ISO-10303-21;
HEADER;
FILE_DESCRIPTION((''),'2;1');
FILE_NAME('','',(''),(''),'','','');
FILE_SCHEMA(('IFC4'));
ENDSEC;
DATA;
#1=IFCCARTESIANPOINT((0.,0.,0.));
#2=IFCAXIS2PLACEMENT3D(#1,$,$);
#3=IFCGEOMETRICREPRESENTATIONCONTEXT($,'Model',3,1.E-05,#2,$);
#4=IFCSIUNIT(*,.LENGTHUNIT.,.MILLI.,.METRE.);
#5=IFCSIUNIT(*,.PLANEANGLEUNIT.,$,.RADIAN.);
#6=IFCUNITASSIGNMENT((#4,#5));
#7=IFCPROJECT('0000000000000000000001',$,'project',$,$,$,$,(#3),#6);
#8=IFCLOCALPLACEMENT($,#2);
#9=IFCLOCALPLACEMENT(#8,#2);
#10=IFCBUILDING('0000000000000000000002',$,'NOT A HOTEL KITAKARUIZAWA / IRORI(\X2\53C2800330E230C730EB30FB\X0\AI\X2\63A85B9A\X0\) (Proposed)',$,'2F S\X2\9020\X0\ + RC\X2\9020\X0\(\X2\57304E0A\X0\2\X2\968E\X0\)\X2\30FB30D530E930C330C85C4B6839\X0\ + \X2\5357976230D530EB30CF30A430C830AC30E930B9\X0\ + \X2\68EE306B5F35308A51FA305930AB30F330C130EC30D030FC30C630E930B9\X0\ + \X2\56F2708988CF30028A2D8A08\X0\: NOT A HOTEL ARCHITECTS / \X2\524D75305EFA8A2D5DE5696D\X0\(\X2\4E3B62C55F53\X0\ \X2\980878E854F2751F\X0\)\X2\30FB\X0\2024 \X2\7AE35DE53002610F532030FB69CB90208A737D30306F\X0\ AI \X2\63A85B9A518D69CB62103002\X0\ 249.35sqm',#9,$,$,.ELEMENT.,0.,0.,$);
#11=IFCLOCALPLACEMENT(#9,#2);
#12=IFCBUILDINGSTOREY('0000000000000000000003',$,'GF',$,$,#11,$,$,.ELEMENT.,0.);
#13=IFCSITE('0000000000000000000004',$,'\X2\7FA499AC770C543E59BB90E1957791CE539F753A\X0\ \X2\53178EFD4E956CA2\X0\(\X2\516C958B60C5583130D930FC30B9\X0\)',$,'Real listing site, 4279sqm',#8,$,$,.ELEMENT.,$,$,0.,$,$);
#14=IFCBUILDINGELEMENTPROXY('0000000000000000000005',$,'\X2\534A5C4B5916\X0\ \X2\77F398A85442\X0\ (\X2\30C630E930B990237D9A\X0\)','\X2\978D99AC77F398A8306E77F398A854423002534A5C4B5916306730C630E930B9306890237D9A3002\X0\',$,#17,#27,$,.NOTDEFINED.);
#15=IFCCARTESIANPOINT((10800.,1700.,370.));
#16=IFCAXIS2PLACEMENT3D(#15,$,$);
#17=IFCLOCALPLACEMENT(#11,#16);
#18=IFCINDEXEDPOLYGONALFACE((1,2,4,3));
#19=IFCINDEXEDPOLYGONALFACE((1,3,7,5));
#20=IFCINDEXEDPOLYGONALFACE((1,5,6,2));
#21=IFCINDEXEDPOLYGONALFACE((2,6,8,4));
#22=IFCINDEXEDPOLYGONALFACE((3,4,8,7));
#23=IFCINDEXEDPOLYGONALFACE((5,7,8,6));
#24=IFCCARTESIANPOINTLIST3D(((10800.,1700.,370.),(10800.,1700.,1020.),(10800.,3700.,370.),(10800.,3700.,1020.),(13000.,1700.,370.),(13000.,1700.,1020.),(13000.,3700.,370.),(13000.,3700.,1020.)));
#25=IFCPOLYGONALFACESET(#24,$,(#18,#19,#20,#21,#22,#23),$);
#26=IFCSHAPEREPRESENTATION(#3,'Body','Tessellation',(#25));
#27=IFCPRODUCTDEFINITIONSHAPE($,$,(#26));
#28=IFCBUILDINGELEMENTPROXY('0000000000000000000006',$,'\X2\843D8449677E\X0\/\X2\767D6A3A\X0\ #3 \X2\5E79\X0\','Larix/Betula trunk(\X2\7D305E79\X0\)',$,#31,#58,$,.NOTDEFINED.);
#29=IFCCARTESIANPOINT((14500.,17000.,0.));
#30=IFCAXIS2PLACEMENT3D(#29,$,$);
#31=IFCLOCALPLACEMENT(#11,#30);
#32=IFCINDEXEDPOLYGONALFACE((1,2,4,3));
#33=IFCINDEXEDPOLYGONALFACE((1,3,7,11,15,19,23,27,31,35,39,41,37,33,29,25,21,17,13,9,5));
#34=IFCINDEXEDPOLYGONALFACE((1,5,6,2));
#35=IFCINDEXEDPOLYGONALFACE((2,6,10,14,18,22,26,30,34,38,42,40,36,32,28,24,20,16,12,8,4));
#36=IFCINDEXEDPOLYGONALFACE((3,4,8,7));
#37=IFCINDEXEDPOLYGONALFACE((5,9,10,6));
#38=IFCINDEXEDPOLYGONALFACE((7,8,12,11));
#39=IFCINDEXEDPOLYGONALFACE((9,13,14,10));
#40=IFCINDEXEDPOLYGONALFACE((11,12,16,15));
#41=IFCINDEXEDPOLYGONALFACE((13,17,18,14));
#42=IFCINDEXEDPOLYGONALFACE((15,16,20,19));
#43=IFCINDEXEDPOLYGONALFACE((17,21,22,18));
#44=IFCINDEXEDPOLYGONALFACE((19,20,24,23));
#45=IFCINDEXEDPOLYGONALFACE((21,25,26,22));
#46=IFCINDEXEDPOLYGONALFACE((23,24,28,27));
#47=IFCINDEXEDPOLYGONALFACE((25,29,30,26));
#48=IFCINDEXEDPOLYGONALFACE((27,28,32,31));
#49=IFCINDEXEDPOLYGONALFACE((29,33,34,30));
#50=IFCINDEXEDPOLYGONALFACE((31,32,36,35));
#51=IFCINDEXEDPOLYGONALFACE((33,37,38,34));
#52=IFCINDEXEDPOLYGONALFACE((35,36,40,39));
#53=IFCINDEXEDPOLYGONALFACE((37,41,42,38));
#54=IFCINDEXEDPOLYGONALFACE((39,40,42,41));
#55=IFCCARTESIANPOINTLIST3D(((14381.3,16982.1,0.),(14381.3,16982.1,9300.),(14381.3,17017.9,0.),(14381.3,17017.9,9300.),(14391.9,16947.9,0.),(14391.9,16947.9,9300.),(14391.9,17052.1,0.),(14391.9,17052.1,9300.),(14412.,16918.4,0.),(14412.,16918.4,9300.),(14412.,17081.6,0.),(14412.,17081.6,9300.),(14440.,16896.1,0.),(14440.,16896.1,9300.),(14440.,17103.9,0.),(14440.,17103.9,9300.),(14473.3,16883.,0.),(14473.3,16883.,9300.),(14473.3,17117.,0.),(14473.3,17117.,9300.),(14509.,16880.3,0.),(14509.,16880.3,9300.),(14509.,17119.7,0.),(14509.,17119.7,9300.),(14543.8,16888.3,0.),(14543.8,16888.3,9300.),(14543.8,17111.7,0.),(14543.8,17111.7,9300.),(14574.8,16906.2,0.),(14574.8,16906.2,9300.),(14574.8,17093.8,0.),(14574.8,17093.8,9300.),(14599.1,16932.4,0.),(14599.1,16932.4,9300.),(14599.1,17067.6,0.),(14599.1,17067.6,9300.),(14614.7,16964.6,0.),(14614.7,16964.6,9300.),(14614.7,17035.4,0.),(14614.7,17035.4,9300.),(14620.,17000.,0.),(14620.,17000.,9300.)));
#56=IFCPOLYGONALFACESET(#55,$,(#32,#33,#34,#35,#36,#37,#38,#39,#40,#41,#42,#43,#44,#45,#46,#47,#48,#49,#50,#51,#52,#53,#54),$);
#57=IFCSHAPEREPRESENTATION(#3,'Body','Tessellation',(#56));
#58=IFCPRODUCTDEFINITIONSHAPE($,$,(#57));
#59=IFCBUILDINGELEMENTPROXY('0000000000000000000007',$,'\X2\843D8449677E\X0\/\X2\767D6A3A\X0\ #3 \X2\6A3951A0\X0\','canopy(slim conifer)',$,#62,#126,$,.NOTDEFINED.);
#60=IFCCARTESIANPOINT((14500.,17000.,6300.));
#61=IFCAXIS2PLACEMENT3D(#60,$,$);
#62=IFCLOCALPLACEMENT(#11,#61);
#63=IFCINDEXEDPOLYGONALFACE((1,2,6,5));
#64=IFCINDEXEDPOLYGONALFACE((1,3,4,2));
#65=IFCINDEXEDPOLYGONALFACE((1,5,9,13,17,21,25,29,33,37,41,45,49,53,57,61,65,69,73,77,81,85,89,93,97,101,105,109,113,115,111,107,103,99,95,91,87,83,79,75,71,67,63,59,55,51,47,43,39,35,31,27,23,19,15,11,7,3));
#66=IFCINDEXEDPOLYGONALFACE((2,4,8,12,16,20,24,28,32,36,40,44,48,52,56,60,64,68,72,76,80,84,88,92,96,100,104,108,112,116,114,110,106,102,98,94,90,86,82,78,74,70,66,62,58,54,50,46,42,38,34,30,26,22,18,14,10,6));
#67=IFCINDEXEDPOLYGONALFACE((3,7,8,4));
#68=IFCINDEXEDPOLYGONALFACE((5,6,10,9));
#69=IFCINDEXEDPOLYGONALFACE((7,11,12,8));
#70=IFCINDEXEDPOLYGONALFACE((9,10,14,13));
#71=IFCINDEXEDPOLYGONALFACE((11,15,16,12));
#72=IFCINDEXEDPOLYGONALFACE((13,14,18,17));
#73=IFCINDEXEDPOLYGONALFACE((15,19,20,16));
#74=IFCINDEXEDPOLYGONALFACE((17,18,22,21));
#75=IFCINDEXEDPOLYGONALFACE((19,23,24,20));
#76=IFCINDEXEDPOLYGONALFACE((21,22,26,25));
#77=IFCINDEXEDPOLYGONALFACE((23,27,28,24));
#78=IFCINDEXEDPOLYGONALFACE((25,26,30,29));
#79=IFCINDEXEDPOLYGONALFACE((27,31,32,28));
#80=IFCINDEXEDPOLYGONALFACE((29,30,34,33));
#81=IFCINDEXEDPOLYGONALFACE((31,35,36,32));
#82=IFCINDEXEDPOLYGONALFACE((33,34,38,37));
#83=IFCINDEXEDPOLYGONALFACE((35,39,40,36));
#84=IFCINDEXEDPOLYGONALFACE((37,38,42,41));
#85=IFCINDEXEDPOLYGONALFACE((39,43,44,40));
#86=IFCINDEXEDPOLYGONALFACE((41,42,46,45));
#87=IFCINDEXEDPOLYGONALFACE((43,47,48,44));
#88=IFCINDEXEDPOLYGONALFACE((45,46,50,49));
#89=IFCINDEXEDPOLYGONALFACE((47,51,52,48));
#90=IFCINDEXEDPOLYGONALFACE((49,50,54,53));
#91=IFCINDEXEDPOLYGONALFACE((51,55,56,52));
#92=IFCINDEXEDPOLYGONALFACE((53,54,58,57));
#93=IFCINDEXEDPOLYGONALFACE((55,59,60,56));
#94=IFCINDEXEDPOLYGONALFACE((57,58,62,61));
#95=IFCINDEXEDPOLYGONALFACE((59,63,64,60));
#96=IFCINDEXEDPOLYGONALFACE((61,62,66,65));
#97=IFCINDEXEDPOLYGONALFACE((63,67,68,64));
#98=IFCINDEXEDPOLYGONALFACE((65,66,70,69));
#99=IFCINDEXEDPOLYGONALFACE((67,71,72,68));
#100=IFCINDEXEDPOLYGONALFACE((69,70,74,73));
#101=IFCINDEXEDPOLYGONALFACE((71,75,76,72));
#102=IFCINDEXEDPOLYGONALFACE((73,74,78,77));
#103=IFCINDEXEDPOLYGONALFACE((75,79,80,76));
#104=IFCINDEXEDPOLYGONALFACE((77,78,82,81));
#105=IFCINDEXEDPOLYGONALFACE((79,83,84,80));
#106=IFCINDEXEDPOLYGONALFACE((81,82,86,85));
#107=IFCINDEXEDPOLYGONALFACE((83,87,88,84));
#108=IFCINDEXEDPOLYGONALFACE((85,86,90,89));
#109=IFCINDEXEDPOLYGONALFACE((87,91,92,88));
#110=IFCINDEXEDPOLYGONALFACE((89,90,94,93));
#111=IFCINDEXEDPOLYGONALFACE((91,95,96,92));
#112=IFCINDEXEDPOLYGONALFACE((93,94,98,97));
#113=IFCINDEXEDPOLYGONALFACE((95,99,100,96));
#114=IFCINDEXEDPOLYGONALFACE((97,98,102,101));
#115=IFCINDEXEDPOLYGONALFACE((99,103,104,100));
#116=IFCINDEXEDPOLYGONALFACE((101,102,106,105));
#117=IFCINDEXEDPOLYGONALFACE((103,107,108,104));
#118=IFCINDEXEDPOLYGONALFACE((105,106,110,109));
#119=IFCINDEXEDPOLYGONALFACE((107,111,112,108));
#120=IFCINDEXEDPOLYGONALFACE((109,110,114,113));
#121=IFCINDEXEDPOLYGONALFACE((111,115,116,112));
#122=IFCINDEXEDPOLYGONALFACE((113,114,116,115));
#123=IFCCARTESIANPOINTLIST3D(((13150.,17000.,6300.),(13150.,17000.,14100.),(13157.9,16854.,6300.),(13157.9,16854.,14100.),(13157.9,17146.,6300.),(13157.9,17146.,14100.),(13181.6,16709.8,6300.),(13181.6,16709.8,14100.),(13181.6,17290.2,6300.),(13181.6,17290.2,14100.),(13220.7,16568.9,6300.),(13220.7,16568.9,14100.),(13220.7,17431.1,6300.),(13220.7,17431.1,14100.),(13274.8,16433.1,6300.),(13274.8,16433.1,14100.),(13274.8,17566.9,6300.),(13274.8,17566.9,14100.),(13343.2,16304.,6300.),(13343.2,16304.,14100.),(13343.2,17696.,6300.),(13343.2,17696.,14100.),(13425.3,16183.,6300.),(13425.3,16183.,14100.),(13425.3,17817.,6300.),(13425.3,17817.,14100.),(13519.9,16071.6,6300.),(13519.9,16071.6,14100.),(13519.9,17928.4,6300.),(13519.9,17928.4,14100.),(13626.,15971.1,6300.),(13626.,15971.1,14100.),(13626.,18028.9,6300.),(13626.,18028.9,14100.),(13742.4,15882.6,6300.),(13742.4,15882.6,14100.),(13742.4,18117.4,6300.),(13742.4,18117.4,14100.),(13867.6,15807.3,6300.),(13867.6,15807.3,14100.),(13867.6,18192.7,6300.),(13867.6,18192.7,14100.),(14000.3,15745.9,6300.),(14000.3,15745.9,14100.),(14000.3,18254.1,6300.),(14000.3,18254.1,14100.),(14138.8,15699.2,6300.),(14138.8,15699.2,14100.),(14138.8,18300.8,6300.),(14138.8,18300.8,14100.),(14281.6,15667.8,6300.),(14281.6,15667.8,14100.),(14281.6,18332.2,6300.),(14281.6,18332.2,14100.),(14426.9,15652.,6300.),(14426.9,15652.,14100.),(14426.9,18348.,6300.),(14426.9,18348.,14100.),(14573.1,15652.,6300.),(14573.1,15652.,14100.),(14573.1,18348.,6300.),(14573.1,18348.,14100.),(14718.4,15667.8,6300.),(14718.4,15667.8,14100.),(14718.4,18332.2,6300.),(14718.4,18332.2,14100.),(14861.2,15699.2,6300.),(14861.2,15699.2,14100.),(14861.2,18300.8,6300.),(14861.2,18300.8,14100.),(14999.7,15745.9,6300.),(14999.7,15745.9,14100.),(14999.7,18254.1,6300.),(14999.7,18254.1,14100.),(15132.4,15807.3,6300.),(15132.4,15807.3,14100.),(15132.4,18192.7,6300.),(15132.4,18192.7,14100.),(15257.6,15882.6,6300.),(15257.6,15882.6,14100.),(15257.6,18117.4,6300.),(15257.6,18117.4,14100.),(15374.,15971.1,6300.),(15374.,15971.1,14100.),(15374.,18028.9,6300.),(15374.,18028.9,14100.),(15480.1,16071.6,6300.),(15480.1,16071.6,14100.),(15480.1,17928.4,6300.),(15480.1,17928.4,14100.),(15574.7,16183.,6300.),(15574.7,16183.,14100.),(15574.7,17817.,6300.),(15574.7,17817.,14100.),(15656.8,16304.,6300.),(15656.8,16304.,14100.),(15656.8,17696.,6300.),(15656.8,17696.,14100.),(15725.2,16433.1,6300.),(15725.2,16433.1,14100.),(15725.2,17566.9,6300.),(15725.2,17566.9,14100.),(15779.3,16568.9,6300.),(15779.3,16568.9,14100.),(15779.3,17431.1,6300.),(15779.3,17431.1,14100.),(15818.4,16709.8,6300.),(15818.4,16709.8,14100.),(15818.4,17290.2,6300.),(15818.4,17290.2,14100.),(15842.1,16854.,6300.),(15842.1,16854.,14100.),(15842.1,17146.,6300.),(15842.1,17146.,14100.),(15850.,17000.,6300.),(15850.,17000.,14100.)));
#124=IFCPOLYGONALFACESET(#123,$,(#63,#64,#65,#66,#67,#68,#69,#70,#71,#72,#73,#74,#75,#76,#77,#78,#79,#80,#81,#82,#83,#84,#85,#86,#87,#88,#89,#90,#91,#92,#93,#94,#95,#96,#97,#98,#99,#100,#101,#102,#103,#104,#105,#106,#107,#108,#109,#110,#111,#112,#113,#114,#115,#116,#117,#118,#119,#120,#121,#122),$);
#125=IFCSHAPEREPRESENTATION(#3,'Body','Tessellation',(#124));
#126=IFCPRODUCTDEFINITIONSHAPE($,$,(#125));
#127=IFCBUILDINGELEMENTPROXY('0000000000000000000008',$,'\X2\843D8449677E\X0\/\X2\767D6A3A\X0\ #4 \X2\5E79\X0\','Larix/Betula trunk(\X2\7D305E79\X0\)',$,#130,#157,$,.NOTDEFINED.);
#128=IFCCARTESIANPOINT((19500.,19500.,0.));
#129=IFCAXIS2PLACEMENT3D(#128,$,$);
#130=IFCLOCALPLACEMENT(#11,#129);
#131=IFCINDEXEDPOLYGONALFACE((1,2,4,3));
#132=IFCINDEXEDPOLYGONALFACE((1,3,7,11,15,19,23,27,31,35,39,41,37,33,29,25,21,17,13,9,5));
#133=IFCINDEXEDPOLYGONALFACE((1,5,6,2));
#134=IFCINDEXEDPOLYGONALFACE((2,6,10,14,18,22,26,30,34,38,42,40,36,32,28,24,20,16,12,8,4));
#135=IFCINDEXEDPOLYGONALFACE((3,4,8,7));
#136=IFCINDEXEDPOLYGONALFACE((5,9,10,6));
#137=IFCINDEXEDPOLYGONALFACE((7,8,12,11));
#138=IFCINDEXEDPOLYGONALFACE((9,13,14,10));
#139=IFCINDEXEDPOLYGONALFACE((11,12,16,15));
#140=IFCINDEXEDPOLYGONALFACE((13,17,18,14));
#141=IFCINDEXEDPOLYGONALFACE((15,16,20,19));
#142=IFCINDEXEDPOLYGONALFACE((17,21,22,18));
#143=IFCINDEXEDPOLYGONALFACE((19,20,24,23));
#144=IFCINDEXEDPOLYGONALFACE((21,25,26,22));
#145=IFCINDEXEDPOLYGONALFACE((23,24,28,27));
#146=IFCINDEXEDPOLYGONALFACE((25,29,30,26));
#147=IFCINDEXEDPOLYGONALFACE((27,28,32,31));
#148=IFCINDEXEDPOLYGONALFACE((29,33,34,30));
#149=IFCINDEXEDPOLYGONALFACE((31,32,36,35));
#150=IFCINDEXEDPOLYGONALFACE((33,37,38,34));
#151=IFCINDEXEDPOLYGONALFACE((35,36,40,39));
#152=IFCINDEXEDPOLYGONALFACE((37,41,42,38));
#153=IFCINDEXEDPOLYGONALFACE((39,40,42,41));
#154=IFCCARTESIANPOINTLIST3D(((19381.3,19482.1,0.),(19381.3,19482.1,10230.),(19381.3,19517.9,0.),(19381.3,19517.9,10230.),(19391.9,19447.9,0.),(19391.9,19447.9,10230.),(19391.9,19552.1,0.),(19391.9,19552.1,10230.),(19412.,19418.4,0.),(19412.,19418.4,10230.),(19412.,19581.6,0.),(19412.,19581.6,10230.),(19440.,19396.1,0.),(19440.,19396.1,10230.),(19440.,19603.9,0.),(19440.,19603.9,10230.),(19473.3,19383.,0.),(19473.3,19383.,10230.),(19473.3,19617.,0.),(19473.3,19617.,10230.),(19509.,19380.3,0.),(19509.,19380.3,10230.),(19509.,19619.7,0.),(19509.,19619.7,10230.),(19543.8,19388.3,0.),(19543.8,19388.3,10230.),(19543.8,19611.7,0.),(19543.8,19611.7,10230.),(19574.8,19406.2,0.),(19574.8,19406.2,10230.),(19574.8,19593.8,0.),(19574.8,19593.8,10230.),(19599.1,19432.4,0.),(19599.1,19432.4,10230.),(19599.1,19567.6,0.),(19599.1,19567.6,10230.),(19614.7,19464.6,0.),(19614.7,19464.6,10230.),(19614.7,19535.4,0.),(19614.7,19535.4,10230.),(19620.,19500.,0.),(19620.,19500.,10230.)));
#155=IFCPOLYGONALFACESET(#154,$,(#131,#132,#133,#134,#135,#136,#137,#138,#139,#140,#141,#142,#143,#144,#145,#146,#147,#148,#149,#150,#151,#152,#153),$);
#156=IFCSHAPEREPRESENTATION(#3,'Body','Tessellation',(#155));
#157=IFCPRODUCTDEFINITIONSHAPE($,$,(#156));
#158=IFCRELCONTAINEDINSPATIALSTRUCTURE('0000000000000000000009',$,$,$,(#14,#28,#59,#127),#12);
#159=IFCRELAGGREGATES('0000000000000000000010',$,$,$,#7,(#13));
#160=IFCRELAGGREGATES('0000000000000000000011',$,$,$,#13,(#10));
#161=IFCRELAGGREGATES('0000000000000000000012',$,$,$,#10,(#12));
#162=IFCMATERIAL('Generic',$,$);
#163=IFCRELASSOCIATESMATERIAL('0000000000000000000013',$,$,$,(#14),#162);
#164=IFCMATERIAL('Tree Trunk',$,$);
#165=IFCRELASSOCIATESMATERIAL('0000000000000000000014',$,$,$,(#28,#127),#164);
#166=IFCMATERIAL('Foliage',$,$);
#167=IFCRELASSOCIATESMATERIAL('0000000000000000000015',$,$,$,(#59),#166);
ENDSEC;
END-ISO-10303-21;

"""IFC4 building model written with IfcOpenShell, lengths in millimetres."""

from ifc_helpers import new_model, si_unit, frame, frame_2d, origin, origin_2d, place, context, project, spatial, rectangle, circle, extrude, material, element, save


model = new_model("IFC4")

# Units and contexts
model_context = context("Model", 3, precision=1e-05, world=origin())
ifc_project = project(units=[si_unit("LENGTHUNIT", "METRE", prefix="MILLI"), si_unit("PLANEANGLEUNIT", "RADIAN")], contexts=[model_context])

# Site, building, storey
site_placement = place(None, origin())
site = spatial("IfcSite", under=ifc_project, at=site_placement, Name="群馬県吾妻郡長野原町 北軽井沢(公開情報ベース)", ObjectType="Real listing site, 4279sqm", CompositionType="ELEMENT", RefElevation=0.0)
building_placement = place(site_placement, origin())
building = spatial("IfcBuilding", under=site, at=building_placement, Name="NOT A HOTEL KITAKARUIZAWA / IRORI(参考モデル・AI推定) (Proposed)", ObjectType="2F S造 + RC造(地上2階)・フラット屋根 + 南面フルハイトガラス + 森に張り出すカンチレバーテラス + 囲炉裏。設計: NOT A HOTEL ARCHITECTS / 前田建設工業(主担当 須磨哲生)・2024 竣工。意匠・構造詳細は AI 推定再構成。 249.35sqm", CompositionType="ELEMENT", ElevationOfRefHeight=0.0, ElevationOfTerrain=0.0)
storey_placement = place(building_placement, origin())
storey = spatial("IfcBuildingStorey", under=building, at=storey_placement, Name="GF", CompositionType="ELEMENT", Elevation=0.0)

# Shared definitions
ifc_material_1 = material(Name="Generic")

# Building element proxies
proxy_1_placement = place(storey_placement, frame((10800.0, 1700.0, 370.0)))
element("IfcBuildingElementProxy", 1, at=proxy_1_placement, inside=storey, material=ifc_material_1, Name="半屋外 石風呂 (テラス連続)", Description="鞍馬石風の石風呂。半屋外でテラスと連続。", PredefinedType="NOTDEFINED", context=model_context, shape_type="SweptSolid", body=[
    extrude(rectangle(XDim=2200.0, YDim=2000.0, at=frame_2d((1100.0, 1000.0))), frame((10800.0, 1700.0, 370.0)), (0.0, 0.0, 1.0), 650.0),
])
ifc_material_2 = material(Name="Tree Trunk")
proxy_2_placement = place(storey_placement, frame((14500.0, 17000.0, 0.0)))
element("IfcBuildingElementProxy", 2, at=proxy_2_placement, inside=storey, material=ifc_material_2, Name="落葉松/白樺 #3 幹", Description="Larix/Betula trunk(細幹)", PredefinedType="NOTDEFINED", context=model_context, shape_type="SweptSolid", body=[
    extrude(circle(Radius=120.0, at=origin_2d()), frame((14500.0, 17000.0, 0.0)), (0.0, 0.0, 1.0), 9300.0),
])
ifc_material_3 = material(Name="Foliage")
proxy_3_placement = place(storey_placement, frame((14500.0, 17000.0, 6300.0)))
element("IfcBuildingElementProxy", 3, at=proxy_3_placement, inside=storey, material=ifc_material_3, Name="落葉松/白樺 #3 樹冠", Description="canopy(slim conifer)", PredefinedType="NOTDEFINED", context=model_context, shape_type="SweptSolid", body=[
    extrude(circle(Radius=1350.0, at=origin_2d()), frame((14500.0, 17000.0, 6300.0)), (0.0, 0.0, 1.0), 7800.0),
])
proxy_4_placement = place(storey_placement, frame((19500.0, 19500.0, 0.0)))
element("IfcBuildingElementProxy", 4, at=proxy_4_placement, inside=storey, material=ifc_material_2, Name="落葉松/白樺 #4 幹", Description="Larix/Betula trunk(細幹)", PredefinedType="NOTDEFINED", context=model_context, shape_type="SweptSolid", body=[
    extrude(circle(Radius=120.0, at=origin_2d()), frame((19500.0, 19500.0, 0.0)), (0.0, 0.0, 1.0), 10230.0),
])

save(model, "model.ifc")
